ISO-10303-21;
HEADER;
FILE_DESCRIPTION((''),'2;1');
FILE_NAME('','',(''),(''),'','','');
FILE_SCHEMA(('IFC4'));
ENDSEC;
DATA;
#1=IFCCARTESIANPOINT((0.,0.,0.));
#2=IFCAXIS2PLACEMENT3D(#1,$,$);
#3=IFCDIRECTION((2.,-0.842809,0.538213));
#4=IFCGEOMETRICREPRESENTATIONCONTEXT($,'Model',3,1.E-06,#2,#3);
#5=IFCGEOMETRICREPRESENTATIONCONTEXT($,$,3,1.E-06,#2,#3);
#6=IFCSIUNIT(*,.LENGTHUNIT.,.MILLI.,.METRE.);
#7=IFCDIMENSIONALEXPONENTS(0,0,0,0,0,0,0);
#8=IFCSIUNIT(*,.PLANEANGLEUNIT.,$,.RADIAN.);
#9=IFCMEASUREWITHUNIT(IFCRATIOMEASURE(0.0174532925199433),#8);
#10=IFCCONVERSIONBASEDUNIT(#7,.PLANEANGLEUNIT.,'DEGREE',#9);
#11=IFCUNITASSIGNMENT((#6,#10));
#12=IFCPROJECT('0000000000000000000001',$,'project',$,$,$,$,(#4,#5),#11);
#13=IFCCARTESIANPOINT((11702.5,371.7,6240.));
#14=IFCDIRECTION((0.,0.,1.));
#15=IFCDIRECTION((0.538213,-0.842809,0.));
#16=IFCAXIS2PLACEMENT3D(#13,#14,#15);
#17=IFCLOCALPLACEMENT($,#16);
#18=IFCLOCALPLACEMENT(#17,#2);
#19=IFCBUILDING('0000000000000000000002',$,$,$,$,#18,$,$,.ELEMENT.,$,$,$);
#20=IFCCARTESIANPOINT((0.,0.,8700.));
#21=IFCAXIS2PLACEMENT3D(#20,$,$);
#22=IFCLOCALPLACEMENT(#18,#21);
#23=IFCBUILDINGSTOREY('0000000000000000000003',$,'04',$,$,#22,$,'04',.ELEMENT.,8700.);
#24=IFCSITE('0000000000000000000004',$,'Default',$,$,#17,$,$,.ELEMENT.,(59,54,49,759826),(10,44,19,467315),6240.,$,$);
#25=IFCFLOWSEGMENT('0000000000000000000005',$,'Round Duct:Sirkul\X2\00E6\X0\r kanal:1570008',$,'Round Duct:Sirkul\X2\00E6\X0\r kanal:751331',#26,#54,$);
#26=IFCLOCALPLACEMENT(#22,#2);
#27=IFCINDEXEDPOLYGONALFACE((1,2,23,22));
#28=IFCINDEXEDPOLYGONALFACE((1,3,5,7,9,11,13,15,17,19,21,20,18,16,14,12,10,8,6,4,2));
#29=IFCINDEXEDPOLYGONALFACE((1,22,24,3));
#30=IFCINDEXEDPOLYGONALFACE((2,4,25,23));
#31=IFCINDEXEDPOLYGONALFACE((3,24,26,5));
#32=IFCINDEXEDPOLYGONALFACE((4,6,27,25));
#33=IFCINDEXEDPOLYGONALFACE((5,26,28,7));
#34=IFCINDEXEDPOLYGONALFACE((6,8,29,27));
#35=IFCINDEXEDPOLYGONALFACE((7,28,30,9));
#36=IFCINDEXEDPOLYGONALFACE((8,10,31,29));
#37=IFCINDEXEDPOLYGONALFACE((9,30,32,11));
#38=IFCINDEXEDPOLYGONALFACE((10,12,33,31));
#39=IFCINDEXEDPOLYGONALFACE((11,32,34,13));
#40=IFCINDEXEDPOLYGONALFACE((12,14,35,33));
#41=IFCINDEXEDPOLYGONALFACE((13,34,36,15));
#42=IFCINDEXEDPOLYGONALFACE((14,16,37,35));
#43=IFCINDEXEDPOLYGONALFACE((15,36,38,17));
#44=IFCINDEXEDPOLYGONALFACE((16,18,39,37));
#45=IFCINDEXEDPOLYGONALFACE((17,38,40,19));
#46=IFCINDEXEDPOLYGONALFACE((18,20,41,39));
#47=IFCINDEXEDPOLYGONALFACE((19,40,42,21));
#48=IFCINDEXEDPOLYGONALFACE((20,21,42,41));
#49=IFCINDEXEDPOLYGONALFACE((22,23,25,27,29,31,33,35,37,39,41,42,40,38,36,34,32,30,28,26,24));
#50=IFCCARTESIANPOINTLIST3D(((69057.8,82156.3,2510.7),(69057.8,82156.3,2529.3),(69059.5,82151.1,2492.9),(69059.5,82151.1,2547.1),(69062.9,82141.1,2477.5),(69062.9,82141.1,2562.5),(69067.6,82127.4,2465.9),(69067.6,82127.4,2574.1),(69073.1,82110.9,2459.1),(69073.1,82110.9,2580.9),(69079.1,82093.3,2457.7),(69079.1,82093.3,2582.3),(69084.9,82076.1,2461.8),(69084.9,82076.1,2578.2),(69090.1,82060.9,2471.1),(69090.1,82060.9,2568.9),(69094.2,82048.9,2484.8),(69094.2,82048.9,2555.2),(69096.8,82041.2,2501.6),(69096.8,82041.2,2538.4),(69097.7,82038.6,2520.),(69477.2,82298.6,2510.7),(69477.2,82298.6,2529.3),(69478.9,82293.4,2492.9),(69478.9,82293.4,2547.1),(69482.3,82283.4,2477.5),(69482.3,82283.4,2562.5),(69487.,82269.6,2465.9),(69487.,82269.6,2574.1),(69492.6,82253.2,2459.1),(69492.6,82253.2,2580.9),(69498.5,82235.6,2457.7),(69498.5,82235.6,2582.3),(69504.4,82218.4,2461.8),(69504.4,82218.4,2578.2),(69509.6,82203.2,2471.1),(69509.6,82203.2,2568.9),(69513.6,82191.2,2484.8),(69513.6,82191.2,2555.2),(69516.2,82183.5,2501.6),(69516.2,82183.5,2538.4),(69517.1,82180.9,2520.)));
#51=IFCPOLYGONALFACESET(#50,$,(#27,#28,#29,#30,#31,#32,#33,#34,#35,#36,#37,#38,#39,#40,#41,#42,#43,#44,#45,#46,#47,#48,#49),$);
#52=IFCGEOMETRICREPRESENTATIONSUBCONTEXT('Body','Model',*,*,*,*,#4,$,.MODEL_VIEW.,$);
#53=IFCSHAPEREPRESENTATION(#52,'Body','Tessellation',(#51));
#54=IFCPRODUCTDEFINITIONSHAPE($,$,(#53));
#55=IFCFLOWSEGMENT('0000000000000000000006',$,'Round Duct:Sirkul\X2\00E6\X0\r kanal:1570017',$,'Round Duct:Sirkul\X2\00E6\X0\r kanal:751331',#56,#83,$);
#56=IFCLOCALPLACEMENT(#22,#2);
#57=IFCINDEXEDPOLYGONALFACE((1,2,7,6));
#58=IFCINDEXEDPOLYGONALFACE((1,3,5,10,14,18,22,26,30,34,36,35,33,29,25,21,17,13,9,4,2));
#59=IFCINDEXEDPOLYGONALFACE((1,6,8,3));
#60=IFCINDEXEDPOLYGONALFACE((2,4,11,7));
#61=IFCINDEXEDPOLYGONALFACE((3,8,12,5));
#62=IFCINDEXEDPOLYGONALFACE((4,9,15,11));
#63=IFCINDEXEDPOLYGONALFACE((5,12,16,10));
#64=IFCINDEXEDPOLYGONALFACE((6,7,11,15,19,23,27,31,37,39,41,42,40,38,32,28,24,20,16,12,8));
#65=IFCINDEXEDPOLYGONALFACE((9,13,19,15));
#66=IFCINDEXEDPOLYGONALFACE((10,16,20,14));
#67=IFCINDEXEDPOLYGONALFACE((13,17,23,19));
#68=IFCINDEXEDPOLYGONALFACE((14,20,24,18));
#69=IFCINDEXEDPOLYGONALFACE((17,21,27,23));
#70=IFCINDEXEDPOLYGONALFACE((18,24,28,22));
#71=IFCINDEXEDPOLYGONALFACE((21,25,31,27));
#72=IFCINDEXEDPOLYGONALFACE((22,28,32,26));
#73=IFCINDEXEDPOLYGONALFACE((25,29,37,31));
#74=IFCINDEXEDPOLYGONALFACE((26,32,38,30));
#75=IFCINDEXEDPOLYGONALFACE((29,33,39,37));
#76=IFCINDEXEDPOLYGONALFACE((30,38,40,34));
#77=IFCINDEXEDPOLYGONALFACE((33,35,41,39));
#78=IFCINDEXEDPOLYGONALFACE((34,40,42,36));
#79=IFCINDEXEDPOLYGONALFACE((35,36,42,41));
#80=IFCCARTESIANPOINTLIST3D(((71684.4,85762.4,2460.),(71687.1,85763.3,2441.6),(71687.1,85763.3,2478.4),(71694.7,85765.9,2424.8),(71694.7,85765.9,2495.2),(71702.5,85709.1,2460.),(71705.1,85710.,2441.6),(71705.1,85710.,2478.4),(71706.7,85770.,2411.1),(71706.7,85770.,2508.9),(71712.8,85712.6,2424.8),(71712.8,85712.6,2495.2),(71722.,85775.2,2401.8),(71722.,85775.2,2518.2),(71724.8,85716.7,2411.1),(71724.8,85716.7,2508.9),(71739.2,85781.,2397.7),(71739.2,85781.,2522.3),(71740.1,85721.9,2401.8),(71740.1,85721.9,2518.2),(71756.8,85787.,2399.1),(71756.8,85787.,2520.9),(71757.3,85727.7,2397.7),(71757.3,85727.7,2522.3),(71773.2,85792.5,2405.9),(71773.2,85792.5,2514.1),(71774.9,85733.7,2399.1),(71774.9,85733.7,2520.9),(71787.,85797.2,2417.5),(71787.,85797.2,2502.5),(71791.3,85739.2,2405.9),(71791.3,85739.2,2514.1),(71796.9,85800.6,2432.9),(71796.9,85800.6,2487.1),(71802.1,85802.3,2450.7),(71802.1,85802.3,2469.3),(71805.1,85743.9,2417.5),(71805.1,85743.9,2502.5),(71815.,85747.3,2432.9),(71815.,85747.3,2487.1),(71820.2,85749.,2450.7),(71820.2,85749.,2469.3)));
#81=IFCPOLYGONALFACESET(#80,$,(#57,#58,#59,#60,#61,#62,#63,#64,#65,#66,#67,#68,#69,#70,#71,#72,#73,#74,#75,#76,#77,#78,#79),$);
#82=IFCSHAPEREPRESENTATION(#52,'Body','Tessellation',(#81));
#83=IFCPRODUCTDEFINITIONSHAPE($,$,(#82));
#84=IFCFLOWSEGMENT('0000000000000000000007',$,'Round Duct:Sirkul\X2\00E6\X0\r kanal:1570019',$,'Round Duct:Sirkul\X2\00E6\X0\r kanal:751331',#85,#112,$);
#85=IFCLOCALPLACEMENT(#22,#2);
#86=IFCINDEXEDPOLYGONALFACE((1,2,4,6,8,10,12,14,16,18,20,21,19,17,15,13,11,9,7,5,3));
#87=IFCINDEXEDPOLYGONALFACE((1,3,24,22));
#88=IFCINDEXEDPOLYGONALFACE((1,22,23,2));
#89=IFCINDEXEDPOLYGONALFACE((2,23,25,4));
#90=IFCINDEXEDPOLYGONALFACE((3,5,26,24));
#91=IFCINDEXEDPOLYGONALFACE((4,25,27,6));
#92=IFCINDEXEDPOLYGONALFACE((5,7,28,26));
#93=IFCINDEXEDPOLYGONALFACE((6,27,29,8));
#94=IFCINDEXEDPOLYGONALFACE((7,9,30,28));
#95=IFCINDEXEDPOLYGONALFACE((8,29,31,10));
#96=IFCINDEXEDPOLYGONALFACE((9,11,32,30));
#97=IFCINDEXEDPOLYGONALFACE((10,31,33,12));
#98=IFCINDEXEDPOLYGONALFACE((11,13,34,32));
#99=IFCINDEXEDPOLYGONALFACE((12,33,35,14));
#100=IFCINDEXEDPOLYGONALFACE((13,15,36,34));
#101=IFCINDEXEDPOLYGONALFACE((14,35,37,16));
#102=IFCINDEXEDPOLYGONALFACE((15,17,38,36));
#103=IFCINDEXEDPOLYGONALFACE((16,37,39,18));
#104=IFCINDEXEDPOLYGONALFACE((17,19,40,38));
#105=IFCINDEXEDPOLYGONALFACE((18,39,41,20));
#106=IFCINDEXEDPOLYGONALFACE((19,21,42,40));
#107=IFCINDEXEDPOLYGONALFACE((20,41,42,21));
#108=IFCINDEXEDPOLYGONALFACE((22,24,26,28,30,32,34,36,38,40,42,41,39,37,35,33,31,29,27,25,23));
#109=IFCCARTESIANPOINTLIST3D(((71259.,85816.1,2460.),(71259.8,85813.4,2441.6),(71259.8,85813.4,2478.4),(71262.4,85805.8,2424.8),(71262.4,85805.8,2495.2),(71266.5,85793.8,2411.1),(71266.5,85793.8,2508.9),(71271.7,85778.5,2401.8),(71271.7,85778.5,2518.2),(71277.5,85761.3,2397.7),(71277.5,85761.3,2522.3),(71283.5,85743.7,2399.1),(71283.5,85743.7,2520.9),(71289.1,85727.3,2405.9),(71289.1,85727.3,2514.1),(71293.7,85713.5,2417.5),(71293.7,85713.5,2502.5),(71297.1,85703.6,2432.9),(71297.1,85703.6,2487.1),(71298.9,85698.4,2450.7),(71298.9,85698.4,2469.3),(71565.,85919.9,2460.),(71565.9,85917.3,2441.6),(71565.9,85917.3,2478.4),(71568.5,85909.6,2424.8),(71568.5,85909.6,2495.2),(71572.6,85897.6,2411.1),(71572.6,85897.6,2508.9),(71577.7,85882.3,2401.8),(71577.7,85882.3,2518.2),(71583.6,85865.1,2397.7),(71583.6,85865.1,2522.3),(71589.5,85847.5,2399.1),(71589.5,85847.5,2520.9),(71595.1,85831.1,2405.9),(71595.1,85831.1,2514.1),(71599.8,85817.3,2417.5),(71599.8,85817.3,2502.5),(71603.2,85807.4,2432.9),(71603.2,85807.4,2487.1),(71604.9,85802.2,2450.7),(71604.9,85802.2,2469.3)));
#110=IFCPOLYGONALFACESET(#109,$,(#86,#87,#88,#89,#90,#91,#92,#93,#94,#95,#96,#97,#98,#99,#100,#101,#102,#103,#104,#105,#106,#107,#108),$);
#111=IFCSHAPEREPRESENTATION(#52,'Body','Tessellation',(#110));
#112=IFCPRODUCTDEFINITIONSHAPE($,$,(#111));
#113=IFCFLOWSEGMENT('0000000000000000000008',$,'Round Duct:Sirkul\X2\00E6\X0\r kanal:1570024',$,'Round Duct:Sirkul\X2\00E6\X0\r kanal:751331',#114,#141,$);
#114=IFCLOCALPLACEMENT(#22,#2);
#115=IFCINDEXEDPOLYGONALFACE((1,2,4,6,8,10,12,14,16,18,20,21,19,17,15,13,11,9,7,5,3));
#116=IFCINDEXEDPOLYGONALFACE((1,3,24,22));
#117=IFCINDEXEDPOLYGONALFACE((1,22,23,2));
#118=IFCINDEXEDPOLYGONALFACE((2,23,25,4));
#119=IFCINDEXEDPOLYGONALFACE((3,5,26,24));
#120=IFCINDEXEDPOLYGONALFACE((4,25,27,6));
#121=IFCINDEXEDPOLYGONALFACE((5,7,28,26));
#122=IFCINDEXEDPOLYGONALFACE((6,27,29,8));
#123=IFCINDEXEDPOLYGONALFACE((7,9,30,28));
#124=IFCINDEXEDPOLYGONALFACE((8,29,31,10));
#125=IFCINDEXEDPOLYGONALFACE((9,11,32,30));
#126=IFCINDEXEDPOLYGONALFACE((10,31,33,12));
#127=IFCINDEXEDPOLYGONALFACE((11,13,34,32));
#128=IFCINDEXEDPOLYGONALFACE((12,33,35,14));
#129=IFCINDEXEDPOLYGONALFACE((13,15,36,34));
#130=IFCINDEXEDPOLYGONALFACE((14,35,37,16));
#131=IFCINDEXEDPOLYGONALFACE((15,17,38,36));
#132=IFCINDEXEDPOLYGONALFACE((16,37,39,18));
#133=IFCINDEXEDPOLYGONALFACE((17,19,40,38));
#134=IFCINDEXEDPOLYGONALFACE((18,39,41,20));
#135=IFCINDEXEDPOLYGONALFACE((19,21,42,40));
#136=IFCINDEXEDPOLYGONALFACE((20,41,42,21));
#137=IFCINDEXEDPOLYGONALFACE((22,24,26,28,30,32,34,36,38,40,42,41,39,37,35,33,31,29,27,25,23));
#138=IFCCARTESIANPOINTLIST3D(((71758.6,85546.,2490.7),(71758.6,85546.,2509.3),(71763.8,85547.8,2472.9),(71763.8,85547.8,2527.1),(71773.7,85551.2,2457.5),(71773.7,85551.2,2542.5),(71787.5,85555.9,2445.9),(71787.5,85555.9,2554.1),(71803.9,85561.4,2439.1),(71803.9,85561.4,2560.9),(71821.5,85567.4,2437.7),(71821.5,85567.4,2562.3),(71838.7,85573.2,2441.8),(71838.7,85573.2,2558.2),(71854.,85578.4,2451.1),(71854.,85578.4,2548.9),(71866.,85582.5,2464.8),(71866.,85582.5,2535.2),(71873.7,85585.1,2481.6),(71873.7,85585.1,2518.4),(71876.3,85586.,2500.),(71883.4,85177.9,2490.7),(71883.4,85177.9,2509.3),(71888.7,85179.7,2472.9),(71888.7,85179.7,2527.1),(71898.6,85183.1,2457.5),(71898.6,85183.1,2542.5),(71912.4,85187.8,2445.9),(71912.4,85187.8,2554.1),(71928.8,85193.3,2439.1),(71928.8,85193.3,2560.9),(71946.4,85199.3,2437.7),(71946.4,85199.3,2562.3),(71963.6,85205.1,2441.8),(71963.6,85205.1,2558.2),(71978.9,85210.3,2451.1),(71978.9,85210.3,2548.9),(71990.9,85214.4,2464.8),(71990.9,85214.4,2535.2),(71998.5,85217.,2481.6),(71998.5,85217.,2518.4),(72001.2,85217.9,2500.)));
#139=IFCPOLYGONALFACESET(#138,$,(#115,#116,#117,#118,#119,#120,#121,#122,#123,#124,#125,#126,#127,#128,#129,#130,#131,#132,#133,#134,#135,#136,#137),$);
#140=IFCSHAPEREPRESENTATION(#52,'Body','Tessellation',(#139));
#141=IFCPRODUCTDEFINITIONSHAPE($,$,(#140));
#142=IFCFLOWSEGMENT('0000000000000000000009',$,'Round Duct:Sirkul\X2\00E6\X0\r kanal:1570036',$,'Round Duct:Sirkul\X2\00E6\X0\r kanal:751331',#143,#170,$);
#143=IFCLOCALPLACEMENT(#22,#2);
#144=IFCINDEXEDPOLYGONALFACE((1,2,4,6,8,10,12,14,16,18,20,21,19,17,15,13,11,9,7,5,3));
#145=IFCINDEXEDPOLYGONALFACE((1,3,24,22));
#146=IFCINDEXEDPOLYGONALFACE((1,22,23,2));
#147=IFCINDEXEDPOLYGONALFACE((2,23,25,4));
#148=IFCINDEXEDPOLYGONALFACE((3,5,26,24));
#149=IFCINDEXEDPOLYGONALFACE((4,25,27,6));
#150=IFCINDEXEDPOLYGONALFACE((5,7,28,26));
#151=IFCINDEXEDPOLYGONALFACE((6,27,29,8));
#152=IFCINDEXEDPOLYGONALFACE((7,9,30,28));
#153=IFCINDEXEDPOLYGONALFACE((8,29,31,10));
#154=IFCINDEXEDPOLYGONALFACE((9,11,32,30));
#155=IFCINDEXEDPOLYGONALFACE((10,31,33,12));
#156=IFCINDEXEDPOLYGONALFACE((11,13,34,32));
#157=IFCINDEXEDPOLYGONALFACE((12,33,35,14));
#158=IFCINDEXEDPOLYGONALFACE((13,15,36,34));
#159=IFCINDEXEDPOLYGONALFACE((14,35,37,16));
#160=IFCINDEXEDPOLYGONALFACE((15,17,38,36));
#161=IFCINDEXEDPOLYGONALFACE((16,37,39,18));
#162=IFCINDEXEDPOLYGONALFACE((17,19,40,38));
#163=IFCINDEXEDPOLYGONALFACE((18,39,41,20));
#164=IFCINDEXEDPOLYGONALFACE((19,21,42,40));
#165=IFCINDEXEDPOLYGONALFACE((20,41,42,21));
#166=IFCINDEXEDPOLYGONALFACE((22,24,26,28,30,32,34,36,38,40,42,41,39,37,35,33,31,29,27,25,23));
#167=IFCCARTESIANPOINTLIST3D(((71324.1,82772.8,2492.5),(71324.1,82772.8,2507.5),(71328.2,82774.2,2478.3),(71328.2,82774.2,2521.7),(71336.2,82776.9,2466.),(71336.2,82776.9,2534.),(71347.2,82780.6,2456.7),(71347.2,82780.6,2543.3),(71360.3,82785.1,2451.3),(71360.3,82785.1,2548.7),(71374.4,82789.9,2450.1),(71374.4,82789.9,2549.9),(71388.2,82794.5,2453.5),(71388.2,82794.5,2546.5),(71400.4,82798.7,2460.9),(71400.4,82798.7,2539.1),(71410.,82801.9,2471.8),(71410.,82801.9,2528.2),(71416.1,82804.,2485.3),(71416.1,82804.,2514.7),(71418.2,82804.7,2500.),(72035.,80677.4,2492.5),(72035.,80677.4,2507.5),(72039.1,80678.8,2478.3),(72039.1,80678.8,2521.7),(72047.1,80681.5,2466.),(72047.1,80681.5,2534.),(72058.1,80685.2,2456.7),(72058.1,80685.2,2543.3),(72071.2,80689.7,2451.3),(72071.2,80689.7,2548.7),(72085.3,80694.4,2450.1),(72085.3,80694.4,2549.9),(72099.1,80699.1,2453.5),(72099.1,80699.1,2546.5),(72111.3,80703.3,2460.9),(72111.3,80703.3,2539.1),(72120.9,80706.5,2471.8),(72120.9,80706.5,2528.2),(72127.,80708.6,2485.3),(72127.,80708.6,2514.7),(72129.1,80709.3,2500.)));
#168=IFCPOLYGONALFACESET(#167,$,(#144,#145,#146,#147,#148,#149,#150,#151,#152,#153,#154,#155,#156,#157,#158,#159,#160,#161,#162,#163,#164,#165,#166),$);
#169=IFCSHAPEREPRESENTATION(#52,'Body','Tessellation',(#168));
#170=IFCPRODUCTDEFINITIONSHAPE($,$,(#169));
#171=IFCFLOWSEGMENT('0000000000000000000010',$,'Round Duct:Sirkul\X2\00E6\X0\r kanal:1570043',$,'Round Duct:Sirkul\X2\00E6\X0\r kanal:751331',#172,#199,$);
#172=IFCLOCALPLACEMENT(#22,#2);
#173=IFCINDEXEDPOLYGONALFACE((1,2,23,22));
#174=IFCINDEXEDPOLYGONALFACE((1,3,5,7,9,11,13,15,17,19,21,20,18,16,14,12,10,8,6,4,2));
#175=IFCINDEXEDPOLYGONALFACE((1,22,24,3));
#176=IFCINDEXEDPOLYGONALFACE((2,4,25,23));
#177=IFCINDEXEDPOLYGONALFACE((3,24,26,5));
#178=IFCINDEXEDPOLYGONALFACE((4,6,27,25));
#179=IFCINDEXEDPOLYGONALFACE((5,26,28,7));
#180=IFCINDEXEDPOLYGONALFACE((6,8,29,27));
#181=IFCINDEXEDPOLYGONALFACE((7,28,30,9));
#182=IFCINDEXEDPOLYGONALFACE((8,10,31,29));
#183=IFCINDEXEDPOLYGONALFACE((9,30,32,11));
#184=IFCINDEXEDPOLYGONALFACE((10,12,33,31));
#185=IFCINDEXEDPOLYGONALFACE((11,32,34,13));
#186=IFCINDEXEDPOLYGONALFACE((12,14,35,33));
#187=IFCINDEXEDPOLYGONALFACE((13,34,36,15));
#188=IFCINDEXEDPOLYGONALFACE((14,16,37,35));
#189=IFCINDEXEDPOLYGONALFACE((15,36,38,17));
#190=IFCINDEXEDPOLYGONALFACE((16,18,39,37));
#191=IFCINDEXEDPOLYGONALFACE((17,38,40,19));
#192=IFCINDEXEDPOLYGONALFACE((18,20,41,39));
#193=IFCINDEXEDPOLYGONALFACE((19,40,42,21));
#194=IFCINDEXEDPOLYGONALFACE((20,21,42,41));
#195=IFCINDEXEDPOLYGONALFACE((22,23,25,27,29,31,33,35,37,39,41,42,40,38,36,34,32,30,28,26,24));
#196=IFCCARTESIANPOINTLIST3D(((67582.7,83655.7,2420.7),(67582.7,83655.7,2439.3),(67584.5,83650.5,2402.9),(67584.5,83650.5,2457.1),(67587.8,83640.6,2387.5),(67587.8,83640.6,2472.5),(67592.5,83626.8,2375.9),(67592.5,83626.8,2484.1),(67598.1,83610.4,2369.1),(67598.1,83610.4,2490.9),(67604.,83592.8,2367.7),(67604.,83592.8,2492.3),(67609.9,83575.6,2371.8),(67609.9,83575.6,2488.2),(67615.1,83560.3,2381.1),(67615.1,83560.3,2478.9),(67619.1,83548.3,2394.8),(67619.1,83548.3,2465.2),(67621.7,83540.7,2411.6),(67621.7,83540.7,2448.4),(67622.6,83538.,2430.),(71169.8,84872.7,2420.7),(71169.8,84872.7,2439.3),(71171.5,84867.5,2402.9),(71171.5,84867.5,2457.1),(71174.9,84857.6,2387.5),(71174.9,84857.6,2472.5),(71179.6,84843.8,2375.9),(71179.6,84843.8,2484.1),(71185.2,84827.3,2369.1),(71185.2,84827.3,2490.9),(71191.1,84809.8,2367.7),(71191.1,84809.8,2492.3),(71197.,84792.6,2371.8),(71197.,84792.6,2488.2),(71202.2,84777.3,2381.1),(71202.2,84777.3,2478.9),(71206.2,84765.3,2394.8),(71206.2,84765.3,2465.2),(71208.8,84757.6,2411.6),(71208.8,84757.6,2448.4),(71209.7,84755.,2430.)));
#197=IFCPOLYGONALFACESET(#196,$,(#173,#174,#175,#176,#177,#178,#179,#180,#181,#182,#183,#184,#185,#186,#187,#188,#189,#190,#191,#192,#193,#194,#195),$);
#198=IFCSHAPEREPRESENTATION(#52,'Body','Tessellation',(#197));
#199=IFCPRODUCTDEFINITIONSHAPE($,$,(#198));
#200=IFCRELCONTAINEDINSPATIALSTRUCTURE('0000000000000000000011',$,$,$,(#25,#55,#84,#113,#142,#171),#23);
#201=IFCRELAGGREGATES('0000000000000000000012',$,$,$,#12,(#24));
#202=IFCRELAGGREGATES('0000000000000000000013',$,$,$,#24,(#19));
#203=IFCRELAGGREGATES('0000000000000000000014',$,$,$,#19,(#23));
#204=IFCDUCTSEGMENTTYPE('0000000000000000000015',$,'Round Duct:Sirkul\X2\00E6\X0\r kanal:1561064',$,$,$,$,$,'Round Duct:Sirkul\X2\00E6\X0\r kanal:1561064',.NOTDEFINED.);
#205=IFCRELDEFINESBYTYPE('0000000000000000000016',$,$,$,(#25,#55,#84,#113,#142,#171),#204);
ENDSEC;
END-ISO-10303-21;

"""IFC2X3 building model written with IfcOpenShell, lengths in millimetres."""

from ifc_helpers import new_model, entity, si_unit, converted_unit, direction, frame, frame_2d, origin, origin_2d_with_axis, place, context, subcontext, project, spatial, circle, extrude, type_object, element, save


model = new_model("IFC2X3")

# Units and contexts
model_context = context("Model", 3, precision=1e-06, world=origin(), true_north=direction((2.0, -0.842809, 0.538213)))
context_of_model = context(None, 3, precision=1e-06, world=origin(), true_north=direction((2.0, -0.842809, 0.538213)))
body_context = subcontext(model_context, "Body", "Model", "MODEL_VIEW")
ifc_project = project(units=[si_unit("LENGTHUNIT", "METRE", prefix="MILLI"), converted_unit("PLANEANGLEUNIT", "DEGREE", entity("IfcRatioMeasure", 0.0174532925199433), si_unit("PLANEANGLEUNIT", "RADIAN"), dimensions=[0, 0, 0, 0, 0, 0, 0])], contexts=[model_context, context_of_model])

# Site, building, storey
site_placement = place(None, frame((11702.5, 371.7, 6240.0), z_axis=(0.0, 0.0, 1.0), x_axis=(0.538213, -0.842809, 0.0)))
site = spatial("IfcSite", under=ifc_project, at=site_placement, Name="Default", CompositionType="ELEMENT", RefLatitude=(59, 54, 49, 759826), RefLongitude=(10, 44, 19, 467315), RefElevation=6240.0)
building_placement = place(site_placement, origin())
building = spatial("IfcBuilding", under=site, at=building_placement, CompositionType="ELEMENT")
storey_placement = place(building_placement, frame((0.0, 0.0, 8700.0)))
storey = spatial("IfcBuildingStorey", under=building, at=storey_placement, Name="04", LongName="04", CompositionType="ELEMENT", Elevation=8700.0)

# Flow segments
duct_segment_type = type_object("IfcDuctSegmentType", Name="Round Duct:Sirkulær kanal:1561064", ElementType="Round Duct:Sirkulær kanal:1561064", PredefinedType="NOTDEFINED")
flow_segment_1_placement = place(storey_placement, origin())
element("IfcFlowSegment", 1, at=flow_segment_1_placement, inside=storey, type_object=duct_segment_type, Name="Round Duct:Sirkulær kanal:1570008", ObjectType="Round Duct:Sirkulær kanal:751331", context=body_context, shape_type="SweptSolid", body=[
    extrude(circle(Radius=62.5, at=origin_2d_with_axis()), frame((69077.6, 82097.8, 2520.0), z_axis=(0.946986, 0.321274, 0.0), x_axis=(0.321274, -0.946986, 0.0)), (0.0, 0.0, 1.0), 442.9),
])
flow_segment_2_placement = place(storey_placement, origin())
element("IfcFlowSegment", 2, at=flow_segment_2_placement, inside=storey, type_object=duct_segment_type, Name="Round Duct:Sirkulær kanal:1570017", ObjectType="Round Duct:Sirkulær kanal:751331", context=body_context, shape_type="SweptSolid", body=[
    extrude(circle(Radius=62.5, at=frame_2d((0.0, 0.0), x_axis=(1.0, 0.0))), frame((71743.6, 85782.5, 2460.0), z_axis=(0.321274, -0.946986, 0.0), x_axis=(-0.946986, -0.321274, 0.0)), (0.0, 0.0, 1.0), 56.3),
])
flow_segment_3_placement = place(storey_placement, origin())
element("IfcFlowSegment", 3, at=flow_segment_3_placement, inside=storey, type_object=duct_segment_type, Name="Round Duct:Sirkulær kanal:1570019", ObjectType="Round Duct:Sirkulær kanal:751331", context=body_context, shape_type="SweptSolid", body=[
    extrude(circle(Radius=62.5, at=origin_2d_with_axis()), frame((71279.0, 85756.9, 2460.0), z_axis=(0.946996, 0.321245, 0.0), x_axis=(-0.321245, 0.946996, 0.0)), (0.0, 0.0, 1.0), 323.2),
])
flow_segment_4_placement = place(storey_placement, origin())
element("IfcFlowSegment", 4, at=flow_segment_4_placement, inside=storey, type_object=duct_segment_type, Name="Round Duct:Sirkulær kanal:1570024", ObjectType="Round Duct:Sirkulær kanal:751331", context=body_context, shape_type="SweptSolid", body=[
    extrude(circle(Radius=62.5, at=origin_2d_with_axis()), frame((71817.1, 85565.9, 2500.0), z_axis=(0.321274, -0.946986, 0.0), x_axis=(0.946986, 0.321274, 0.0)), (0.0, 0.0, 1.0), 388.7),
])
flow_segment_5_placement = place(storey_placement, origin())
element("IfcFlowSegment", 5, at=flow_segment_5_placement, inside=storey, type_object=duct_segment_type, Name="Round Duct:Sirkulær kanal:1570036", ObjectType="Round Duct:Sirkulær kanal:751331", context=body_context, shape_type="SweptSolid", body=[
    extrude(circle(Radius=50.0, at=origin_2d_with_axis()), frame((71370.9, 82788.7, 2500.0), z_axis=(0.321274, -0.946986, 0.0), x_axis=(0.946986, 0.321274, 0.0)), (0.0, 0.0, 1.0), 2212.7),
])
flow_segment_6_placement = place(storey_placement, origin())
element("IfcFlowSegment", 6, at=flow_segment_6_placement, inside=storey, type_object=duct_segment_type, Name="Round Duct:Sirkulær kanal:1570043", ObjectType="Round Duct:Sirkulær kanal:751331", context=body_context, shape_type="SweptSolid", body=[
    extrude(circle(Radius=62.5, at=origin_2d_with_axis()), frame((67602.5, 83597.2, 2430.0), z_axis=(0.946986, 0.321274, 0.0), x_axis=(0.321274, -0.946986, 0.0)), (0.0, 0.0, 1.0), 3787.9),
])

save(model, "model.ifc")
